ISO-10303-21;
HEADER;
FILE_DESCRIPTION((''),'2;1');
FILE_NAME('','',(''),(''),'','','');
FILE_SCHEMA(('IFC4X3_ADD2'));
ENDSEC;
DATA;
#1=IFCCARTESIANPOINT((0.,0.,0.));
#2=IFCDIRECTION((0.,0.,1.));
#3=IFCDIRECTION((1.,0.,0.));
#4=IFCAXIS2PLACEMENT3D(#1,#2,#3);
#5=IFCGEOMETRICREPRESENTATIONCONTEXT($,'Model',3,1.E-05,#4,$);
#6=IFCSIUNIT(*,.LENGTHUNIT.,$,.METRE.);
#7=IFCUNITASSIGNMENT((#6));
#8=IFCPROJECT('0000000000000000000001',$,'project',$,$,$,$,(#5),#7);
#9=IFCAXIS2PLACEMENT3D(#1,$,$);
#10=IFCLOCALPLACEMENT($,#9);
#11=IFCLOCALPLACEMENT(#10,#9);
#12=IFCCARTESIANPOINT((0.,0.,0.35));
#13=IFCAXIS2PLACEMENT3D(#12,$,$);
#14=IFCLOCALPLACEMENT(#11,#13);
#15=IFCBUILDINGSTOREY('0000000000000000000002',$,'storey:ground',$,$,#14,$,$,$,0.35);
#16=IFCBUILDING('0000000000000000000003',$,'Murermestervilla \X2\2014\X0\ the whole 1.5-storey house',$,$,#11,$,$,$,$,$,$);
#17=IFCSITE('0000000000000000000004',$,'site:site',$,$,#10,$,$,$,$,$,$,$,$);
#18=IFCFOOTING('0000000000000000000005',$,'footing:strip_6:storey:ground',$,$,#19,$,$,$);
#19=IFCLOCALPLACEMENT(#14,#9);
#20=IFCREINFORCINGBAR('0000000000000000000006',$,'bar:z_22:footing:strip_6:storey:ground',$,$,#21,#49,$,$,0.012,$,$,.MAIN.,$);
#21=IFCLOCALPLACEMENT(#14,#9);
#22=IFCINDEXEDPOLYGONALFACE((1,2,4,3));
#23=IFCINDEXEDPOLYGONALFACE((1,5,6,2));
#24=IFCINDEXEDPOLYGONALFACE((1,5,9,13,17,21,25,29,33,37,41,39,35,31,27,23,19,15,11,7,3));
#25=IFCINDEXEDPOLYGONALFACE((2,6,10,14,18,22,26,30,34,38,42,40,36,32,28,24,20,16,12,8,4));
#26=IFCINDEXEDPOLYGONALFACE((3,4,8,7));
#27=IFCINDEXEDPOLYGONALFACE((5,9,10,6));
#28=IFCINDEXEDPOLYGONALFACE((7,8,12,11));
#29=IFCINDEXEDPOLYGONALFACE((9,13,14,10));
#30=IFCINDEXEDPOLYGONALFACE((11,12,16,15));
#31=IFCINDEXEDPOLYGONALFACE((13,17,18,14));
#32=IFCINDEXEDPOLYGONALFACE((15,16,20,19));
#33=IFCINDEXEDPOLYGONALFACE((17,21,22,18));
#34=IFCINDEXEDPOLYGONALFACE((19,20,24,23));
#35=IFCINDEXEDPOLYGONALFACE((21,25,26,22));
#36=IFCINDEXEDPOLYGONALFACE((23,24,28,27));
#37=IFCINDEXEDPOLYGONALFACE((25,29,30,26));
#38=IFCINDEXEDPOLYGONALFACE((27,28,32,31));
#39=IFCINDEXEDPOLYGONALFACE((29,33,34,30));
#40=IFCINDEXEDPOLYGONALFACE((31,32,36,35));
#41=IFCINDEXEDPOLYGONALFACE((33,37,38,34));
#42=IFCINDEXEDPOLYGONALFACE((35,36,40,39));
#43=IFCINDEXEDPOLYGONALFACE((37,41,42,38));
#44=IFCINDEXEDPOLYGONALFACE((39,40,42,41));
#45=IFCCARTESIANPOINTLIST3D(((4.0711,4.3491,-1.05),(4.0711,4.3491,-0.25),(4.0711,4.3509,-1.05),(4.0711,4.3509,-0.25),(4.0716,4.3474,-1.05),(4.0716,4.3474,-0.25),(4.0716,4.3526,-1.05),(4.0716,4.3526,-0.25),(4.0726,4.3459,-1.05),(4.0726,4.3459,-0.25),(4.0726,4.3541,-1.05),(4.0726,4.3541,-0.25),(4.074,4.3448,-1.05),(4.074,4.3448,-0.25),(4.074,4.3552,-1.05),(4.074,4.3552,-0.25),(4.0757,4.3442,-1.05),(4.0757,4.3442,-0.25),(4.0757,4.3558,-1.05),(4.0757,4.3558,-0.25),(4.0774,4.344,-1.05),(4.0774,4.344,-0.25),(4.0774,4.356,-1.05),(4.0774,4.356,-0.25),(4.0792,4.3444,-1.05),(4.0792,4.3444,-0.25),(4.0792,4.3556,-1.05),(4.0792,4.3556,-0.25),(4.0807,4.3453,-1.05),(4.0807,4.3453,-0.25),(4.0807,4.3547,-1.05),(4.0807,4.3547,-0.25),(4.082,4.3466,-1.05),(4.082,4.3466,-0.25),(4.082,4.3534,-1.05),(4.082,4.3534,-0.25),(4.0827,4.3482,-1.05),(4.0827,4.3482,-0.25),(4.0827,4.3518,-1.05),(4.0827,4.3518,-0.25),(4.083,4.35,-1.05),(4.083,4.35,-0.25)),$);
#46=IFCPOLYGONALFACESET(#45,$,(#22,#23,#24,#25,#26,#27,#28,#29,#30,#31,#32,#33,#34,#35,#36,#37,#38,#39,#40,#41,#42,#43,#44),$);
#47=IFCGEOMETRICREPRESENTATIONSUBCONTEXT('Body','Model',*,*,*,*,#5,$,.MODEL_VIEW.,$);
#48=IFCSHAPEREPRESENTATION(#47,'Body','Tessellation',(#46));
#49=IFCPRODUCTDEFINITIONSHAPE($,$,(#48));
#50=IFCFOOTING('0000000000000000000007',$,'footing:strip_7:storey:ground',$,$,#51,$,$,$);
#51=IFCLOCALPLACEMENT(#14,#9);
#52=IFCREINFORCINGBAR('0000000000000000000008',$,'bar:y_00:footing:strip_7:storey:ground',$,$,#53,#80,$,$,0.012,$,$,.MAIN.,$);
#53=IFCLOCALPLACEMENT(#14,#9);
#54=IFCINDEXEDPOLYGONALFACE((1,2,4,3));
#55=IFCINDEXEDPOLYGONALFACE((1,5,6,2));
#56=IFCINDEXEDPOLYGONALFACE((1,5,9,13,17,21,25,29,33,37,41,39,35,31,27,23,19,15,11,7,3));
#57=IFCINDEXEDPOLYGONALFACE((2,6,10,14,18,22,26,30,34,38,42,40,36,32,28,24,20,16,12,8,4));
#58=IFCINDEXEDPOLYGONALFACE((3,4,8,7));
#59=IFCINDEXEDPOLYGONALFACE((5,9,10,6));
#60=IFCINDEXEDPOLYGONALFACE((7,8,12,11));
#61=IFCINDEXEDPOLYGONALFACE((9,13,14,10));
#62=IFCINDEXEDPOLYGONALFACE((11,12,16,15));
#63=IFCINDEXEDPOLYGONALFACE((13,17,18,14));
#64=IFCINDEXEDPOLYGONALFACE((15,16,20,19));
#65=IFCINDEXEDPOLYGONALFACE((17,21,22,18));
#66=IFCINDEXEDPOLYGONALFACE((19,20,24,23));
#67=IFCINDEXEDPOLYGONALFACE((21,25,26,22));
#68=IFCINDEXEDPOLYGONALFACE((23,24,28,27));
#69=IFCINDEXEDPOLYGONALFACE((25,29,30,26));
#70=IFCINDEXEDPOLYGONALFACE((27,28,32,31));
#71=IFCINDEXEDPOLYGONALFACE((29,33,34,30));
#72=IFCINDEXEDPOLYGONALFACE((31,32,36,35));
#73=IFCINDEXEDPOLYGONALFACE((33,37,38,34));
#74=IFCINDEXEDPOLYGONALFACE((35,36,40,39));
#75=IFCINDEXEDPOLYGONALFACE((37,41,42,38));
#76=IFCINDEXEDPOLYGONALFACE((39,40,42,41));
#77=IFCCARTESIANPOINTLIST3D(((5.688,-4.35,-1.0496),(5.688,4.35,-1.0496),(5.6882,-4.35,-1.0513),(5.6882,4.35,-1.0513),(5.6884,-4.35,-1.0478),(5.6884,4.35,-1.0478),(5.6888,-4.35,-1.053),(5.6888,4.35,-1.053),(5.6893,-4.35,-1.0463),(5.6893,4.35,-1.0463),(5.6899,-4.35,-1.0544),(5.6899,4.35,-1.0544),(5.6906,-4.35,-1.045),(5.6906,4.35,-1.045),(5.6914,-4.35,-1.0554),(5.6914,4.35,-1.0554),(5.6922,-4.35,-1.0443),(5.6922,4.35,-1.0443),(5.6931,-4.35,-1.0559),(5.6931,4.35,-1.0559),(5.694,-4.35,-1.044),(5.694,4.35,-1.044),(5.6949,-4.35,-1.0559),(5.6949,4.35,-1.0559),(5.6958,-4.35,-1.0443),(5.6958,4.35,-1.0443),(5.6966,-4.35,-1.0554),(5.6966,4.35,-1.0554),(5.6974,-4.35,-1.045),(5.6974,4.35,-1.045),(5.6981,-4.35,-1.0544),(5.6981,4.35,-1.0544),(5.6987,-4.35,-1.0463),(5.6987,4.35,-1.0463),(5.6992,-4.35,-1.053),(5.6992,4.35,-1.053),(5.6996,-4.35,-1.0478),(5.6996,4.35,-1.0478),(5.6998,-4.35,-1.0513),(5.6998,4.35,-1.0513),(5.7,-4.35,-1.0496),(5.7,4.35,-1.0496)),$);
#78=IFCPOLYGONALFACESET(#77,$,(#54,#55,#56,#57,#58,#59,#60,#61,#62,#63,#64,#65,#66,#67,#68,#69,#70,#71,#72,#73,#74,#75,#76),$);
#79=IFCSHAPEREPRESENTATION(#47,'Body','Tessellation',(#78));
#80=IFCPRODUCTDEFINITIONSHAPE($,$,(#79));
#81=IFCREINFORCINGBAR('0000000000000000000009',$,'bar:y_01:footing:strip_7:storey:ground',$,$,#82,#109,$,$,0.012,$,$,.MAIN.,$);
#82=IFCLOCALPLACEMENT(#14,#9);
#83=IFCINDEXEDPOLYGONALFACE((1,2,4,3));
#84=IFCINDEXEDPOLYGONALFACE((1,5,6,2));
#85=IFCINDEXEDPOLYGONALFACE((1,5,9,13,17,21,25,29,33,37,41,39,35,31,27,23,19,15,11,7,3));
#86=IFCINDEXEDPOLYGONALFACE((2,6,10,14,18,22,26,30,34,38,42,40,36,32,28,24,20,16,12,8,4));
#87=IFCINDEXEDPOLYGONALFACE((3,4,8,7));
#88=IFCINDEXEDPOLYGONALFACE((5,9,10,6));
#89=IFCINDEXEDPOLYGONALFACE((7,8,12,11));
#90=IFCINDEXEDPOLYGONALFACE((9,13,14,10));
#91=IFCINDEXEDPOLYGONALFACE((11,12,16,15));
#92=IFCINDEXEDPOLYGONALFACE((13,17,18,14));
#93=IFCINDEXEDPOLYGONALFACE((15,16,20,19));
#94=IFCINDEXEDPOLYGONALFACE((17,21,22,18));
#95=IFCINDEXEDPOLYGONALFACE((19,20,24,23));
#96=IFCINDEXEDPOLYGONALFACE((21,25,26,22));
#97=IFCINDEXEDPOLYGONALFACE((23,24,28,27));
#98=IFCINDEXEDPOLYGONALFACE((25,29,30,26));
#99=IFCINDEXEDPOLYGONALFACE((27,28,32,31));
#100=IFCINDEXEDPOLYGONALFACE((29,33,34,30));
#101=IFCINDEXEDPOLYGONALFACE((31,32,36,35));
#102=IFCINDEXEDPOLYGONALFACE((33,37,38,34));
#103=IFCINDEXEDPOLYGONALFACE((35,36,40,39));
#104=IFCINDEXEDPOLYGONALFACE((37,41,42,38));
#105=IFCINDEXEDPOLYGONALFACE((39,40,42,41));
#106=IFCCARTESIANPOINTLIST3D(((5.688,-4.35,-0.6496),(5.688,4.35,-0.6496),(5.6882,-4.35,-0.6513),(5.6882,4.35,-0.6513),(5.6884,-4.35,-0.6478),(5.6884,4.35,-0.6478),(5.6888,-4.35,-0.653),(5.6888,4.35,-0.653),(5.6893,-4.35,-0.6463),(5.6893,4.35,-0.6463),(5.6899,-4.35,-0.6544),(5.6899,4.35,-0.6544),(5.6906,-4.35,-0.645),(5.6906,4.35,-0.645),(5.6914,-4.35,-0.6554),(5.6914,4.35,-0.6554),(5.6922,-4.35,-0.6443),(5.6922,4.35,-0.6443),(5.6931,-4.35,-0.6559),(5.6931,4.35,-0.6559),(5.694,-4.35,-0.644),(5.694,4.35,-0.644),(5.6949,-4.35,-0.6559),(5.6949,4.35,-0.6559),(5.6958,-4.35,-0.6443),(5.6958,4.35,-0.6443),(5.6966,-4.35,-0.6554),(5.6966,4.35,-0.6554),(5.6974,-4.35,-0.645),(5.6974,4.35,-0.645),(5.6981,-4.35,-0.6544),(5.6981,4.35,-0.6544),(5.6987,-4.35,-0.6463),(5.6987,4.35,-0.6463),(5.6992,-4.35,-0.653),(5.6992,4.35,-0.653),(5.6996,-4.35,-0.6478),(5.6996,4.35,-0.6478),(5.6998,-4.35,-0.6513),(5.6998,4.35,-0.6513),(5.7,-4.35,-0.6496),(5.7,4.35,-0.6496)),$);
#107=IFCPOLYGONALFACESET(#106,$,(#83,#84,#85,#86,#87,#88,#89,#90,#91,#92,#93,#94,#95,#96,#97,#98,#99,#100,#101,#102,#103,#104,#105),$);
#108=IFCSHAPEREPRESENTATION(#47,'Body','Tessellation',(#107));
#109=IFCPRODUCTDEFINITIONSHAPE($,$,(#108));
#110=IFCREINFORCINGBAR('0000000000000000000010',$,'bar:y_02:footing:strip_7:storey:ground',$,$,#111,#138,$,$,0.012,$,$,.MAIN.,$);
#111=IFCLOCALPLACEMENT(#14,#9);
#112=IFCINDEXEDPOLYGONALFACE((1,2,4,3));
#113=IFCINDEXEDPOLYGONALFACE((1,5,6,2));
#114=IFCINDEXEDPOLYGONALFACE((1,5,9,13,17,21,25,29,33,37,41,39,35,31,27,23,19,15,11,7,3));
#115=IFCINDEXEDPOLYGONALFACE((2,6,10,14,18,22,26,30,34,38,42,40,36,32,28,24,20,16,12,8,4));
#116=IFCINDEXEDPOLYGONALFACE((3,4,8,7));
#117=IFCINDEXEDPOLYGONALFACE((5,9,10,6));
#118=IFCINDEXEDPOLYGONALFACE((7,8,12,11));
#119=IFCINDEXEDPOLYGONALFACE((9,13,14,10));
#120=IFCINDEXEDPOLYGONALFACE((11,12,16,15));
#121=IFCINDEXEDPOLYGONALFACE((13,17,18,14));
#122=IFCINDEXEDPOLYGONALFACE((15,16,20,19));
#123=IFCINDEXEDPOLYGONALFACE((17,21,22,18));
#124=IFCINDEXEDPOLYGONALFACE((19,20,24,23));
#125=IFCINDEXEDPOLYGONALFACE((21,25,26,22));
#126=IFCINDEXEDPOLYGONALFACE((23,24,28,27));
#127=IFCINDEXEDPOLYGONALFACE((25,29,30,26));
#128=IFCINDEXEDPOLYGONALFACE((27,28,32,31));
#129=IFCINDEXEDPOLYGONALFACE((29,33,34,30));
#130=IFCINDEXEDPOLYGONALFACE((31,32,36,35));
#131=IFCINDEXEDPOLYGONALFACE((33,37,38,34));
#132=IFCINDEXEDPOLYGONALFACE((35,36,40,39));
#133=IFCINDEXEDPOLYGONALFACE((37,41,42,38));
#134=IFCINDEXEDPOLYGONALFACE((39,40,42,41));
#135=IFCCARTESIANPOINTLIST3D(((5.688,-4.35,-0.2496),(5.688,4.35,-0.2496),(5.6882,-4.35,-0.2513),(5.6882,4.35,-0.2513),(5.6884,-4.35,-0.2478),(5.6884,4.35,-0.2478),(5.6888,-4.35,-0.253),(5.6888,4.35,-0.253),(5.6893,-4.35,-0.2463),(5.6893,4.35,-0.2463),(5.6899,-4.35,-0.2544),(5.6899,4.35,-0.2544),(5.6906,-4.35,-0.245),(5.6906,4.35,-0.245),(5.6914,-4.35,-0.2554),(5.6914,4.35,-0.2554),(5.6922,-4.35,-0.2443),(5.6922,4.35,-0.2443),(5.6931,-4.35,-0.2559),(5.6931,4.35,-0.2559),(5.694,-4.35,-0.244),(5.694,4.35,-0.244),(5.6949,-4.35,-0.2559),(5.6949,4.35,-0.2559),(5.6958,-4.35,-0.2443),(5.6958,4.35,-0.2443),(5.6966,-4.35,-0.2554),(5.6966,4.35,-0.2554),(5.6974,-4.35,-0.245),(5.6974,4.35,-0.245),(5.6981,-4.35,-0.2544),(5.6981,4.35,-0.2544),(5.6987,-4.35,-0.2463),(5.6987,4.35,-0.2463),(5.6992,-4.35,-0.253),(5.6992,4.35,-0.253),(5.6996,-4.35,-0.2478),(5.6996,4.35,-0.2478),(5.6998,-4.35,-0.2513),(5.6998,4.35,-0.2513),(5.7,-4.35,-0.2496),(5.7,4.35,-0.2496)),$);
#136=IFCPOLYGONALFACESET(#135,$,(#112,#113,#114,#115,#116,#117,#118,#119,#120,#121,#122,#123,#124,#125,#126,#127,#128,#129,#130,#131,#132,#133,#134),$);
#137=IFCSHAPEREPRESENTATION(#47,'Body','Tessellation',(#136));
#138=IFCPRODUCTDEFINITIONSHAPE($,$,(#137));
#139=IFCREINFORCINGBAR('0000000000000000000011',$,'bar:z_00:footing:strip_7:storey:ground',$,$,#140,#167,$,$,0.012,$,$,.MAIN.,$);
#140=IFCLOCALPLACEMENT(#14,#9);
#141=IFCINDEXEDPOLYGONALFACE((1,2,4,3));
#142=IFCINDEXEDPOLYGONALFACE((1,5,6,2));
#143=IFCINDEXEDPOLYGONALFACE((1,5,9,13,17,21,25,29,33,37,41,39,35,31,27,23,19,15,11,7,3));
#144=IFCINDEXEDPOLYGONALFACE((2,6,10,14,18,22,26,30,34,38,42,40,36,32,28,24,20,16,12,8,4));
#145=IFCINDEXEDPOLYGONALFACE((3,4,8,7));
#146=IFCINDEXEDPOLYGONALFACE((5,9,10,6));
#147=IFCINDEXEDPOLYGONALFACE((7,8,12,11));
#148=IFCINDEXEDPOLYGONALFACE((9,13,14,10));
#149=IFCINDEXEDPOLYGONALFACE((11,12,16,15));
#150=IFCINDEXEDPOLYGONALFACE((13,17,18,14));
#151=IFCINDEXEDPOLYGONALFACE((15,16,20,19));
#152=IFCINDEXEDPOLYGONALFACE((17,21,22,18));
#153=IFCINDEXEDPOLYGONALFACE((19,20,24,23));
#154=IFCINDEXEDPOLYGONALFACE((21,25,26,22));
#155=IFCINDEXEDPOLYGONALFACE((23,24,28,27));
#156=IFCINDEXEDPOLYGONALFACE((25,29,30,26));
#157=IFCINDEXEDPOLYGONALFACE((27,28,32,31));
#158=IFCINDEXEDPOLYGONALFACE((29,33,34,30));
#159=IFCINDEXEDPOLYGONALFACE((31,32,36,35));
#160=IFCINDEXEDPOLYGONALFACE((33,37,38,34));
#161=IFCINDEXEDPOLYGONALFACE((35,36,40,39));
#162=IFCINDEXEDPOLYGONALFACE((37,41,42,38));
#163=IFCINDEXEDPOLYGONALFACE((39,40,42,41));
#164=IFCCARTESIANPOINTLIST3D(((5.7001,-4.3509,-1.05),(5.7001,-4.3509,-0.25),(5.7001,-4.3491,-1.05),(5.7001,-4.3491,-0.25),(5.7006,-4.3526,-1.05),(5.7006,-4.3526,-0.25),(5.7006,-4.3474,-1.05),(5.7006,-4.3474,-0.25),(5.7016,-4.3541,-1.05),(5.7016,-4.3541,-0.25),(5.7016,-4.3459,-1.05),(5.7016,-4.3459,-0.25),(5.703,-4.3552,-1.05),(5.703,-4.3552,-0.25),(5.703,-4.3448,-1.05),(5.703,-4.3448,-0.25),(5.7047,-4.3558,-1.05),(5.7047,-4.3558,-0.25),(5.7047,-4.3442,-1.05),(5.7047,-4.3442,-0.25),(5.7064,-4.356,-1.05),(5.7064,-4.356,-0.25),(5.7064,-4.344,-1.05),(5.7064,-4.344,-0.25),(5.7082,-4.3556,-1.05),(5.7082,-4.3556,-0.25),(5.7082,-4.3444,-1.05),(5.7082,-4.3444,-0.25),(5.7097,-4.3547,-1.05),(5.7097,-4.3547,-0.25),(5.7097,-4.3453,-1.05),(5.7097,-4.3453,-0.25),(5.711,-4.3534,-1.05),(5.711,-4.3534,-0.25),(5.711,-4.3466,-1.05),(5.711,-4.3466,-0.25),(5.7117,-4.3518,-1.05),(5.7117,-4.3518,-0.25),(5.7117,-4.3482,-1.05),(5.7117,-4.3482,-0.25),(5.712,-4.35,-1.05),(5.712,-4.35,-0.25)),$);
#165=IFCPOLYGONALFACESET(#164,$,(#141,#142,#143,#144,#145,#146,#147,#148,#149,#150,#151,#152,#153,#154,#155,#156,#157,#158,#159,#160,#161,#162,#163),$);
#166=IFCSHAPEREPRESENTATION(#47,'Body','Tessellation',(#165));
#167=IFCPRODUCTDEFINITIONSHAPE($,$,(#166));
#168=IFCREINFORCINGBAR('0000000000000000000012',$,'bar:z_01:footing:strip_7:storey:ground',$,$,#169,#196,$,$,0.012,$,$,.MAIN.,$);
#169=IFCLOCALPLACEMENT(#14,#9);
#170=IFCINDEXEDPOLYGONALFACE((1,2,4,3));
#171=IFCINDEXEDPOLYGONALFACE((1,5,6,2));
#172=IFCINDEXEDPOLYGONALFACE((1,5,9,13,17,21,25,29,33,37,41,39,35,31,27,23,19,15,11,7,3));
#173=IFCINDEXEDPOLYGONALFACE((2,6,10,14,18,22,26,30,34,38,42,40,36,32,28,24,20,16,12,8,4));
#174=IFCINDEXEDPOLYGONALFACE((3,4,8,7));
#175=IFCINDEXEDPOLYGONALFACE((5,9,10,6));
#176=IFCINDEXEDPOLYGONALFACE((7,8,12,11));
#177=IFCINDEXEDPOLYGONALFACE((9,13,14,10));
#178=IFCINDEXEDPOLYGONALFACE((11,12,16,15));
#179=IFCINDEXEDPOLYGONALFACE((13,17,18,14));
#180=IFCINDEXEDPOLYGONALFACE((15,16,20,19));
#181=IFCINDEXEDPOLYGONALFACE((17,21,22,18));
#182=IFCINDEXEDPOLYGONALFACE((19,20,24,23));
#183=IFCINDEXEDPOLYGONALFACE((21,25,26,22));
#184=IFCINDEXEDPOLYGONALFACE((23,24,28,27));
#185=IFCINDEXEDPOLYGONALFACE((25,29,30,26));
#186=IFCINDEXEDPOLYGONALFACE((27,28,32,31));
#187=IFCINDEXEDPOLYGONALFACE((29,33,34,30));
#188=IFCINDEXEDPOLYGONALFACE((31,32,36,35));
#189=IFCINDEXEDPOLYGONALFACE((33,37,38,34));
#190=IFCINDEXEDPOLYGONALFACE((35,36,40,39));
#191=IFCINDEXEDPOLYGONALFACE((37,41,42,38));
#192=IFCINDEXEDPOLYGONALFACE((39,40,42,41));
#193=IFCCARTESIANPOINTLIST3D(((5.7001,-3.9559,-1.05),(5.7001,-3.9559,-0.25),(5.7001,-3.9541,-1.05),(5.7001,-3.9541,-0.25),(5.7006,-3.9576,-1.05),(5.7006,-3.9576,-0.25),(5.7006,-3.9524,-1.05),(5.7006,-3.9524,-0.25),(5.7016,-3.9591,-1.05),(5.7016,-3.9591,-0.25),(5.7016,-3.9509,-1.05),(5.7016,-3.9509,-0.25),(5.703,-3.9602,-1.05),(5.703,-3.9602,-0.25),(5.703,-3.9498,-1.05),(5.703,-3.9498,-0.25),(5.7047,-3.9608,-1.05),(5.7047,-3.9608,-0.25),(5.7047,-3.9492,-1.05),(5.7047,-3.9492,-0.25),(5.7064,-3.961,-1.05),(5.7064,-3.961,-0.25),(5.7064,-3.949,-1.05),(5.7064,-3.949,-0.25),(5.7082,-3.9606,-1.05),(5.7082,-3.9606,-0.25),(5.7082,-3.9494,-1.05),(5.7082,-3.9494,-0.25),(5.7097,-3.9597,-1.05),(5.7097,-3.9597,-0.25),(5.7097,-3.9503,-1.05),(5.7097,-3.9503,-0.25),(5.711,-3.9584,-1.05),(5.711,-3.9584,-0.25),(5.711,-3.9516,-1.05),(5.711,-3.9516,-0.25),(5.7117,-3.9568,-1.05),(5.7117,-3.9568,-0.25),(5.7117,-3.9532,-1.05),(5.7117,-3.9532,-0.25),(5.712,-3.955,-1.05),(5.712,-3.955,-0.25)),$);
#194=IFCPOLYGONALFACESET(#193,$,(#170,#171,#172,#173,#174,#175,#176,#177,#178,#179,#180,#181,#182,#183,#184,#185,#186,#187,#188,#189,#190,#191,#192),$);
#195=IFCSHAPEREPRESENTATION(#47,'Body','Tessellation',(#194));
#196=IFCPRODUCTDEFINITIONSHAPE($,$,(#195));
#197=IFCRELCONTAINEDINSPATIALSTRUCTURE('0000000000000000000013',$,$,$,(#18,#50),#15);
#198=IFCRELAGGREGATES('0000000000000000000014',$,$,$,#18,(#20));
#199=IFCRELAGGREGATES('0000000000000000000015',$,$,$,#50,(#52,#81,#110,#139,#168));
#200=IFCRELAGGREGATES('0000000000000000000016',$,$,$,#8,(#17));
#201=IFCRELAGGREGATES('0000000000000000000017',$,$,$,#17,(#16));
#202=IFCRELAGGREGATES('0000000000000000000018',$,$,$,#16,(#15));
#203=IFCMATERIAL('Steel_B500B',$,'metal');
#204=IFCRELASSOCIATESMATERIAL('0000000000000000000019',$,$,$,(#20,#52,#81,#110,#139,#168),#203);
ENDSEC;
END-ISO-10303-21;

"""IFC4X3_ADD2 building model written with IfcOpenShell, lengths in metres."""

from ifc_helpers import new_model, entity, si_unit, frame, origin, origin_with_axes, place, context, subcontext, project, spatial, material, element, aggregate, save


model = new_model("IFC4X3_ADD2")

# Units and contexts
model_context = context("Model", 3, precision=1e-05, world=origin_with_axes())
body_context = subcontext(model_context, "Body", "Model", "MODEL_VIEW")
ifc_project = project(units=[si_unit("LENGTHUNIT", "METRE")], contexts=[model_context])

# Site, building, storey
placement_1 = place(None, origin())
site = spatial("IfcSite", under=ifc_project, at=placement_1, Name="site:site")
building_placement = place(placement_1, origin())
building = spatial("IfcBuilding", under=site, at=building_placement, Name="Murermestervilla — the whole 1.5-storey house")
storey_placement = place(building_placement, frame((0.0, 0.0, 0.35)))
storey = spatial("IfcBuildingStorey", under=building, at=storey_placement, Name="storey:ground", Elevation=0.35)

# Footings, reinforcing bars
placement_2 = place(storey_placement, frame((0.0, 0.0, -0.35)))
footing_1 = element("IfcFooting", 1, at=placement_2, inside=storey, Name="footing:strip_6:storey:ground")
ifc_material = material(Name="Steel_B500B", Category="metal")
reinforcing_bar_1 = element("IfcReinforcingBar", 2, at=placement_1, material=ifc_material, Name="bar:z_22:footing:strip_6:storey:ground", NominalDiameter=0.012, PredefinedType="MAIN", context=body_context, shape_type="AdvancedSweptSolid", body=[
    entity("IfcSweptDiskSolid", entity("IfcPolyline", [entity("IfcCartesianPoint", [4.077, 4.35, -0.7]), entity("IfcCartesianPoint", [4.077, 4.35, 0.1])]), 0.006),
])
aggregate(footing_1, [reinforcing_bar_1])
footing_2 = element("IfcFooting", 3, at=placement_2, inside=storey, Name="footing:strip_7:storey:ground")
reinforcing_bar_2 = element("IfcReinforcingBar", 4, at=placement_1, material=ifc_material, Name="bar:y_00:footing:strip_7:storey:ground", NominalDiameter=0.012, PredefinedType="MAIN", context=body_context, shape_type="AdvancedSweptSolid", body=[
    entity("IfcSweptDiskSolid", entity("IfcPolyline", [entity("IfcCartesianPoint", [5.694, -4.35, -0.7]), entity("IfcCartesianPoint", [5.694, 4.35, -0.7])]), 0.006),
])
reinforcing_bar_3 = element("IfcReinforcingBar", 5, at=placement_1, material=ifc_material, Name="bar:y_01:footing:strip_7:storey:ground", NominalDiameter=0.012, PredefinedType="MAIN", context=body_context, shape_type="AdvancedSweptSolid", body=[
    entity("IfcSweptDiskSolid", entity("IfcPolyline", [entity("IfcCartesianPoint", [5.694, -4.35, -0.3]), entity("IfcCartesianPoint", [5.694, 4.35, -0.3])]), 0.006),
])
reinforcing_bar_4 = element("IfcReinforcingBar", 6, at=placement_1, material=ifc_material, Name="bar:y_02:footing:strip_7:storey:ground", NominalDiameter=0.012, PredefinedType="MAIN", context=body_context, shape_type="AdvancedSweptSolid", body=[
    entity("IfcSweptDiskSolid", entity("IfcPolyline", [entity("IfcCartesianPoint", [5.694, -4.35, 0.1]), entity("IfcCartesianPoint", [5.694, 4.35, 0.1])]), 0.006),
])
reinforcing_bar_5 = element("IfcReinforcingBar", 7, at=placement_1, material=ifc_material, Name="bar:z_00:footing:strip_7:storey:ground", NominalDiameter=0.012, PredefinedType="MAIN", context=body_context, shape_type="AdvancedSweptSolid", body=[
    entity("IfcSweptDiskSolid", entity("IfcPolyline", [entity("IfcCartesianPoint", [5.706, -4.35, -0.7]), entity("IfcCartesianPoint", [5.706, -4.35, 0.1])]), 0.006),
])
reinforcing_bar_6 = element("IfcReinforcingBar", 8, at=placement_1, material=ifc_material, Name="bar:z_01:footing:strip_7:storey:ground", NominalDiameter=0.012, PredefinedType="MAIN", context=body_context, shape_type="AdvancedSweptSolid", body=[
    entity("IfcSweptDiskSolid", entity("IfcPolyline", [entity("IfcCartesianPoint", [5.706, -3.955, -0.7]), entity("IfcCartesianPoint", [5.706, -3.955, 0.1])]), 0.006),
])
aggregate(footing_2, [reinforcing_bar_2, reinforcing_bar_3, reinforcing_bar_4, reinforcing_bar_5, reinforcing_bar_6])

save(model, "model.ifc")
